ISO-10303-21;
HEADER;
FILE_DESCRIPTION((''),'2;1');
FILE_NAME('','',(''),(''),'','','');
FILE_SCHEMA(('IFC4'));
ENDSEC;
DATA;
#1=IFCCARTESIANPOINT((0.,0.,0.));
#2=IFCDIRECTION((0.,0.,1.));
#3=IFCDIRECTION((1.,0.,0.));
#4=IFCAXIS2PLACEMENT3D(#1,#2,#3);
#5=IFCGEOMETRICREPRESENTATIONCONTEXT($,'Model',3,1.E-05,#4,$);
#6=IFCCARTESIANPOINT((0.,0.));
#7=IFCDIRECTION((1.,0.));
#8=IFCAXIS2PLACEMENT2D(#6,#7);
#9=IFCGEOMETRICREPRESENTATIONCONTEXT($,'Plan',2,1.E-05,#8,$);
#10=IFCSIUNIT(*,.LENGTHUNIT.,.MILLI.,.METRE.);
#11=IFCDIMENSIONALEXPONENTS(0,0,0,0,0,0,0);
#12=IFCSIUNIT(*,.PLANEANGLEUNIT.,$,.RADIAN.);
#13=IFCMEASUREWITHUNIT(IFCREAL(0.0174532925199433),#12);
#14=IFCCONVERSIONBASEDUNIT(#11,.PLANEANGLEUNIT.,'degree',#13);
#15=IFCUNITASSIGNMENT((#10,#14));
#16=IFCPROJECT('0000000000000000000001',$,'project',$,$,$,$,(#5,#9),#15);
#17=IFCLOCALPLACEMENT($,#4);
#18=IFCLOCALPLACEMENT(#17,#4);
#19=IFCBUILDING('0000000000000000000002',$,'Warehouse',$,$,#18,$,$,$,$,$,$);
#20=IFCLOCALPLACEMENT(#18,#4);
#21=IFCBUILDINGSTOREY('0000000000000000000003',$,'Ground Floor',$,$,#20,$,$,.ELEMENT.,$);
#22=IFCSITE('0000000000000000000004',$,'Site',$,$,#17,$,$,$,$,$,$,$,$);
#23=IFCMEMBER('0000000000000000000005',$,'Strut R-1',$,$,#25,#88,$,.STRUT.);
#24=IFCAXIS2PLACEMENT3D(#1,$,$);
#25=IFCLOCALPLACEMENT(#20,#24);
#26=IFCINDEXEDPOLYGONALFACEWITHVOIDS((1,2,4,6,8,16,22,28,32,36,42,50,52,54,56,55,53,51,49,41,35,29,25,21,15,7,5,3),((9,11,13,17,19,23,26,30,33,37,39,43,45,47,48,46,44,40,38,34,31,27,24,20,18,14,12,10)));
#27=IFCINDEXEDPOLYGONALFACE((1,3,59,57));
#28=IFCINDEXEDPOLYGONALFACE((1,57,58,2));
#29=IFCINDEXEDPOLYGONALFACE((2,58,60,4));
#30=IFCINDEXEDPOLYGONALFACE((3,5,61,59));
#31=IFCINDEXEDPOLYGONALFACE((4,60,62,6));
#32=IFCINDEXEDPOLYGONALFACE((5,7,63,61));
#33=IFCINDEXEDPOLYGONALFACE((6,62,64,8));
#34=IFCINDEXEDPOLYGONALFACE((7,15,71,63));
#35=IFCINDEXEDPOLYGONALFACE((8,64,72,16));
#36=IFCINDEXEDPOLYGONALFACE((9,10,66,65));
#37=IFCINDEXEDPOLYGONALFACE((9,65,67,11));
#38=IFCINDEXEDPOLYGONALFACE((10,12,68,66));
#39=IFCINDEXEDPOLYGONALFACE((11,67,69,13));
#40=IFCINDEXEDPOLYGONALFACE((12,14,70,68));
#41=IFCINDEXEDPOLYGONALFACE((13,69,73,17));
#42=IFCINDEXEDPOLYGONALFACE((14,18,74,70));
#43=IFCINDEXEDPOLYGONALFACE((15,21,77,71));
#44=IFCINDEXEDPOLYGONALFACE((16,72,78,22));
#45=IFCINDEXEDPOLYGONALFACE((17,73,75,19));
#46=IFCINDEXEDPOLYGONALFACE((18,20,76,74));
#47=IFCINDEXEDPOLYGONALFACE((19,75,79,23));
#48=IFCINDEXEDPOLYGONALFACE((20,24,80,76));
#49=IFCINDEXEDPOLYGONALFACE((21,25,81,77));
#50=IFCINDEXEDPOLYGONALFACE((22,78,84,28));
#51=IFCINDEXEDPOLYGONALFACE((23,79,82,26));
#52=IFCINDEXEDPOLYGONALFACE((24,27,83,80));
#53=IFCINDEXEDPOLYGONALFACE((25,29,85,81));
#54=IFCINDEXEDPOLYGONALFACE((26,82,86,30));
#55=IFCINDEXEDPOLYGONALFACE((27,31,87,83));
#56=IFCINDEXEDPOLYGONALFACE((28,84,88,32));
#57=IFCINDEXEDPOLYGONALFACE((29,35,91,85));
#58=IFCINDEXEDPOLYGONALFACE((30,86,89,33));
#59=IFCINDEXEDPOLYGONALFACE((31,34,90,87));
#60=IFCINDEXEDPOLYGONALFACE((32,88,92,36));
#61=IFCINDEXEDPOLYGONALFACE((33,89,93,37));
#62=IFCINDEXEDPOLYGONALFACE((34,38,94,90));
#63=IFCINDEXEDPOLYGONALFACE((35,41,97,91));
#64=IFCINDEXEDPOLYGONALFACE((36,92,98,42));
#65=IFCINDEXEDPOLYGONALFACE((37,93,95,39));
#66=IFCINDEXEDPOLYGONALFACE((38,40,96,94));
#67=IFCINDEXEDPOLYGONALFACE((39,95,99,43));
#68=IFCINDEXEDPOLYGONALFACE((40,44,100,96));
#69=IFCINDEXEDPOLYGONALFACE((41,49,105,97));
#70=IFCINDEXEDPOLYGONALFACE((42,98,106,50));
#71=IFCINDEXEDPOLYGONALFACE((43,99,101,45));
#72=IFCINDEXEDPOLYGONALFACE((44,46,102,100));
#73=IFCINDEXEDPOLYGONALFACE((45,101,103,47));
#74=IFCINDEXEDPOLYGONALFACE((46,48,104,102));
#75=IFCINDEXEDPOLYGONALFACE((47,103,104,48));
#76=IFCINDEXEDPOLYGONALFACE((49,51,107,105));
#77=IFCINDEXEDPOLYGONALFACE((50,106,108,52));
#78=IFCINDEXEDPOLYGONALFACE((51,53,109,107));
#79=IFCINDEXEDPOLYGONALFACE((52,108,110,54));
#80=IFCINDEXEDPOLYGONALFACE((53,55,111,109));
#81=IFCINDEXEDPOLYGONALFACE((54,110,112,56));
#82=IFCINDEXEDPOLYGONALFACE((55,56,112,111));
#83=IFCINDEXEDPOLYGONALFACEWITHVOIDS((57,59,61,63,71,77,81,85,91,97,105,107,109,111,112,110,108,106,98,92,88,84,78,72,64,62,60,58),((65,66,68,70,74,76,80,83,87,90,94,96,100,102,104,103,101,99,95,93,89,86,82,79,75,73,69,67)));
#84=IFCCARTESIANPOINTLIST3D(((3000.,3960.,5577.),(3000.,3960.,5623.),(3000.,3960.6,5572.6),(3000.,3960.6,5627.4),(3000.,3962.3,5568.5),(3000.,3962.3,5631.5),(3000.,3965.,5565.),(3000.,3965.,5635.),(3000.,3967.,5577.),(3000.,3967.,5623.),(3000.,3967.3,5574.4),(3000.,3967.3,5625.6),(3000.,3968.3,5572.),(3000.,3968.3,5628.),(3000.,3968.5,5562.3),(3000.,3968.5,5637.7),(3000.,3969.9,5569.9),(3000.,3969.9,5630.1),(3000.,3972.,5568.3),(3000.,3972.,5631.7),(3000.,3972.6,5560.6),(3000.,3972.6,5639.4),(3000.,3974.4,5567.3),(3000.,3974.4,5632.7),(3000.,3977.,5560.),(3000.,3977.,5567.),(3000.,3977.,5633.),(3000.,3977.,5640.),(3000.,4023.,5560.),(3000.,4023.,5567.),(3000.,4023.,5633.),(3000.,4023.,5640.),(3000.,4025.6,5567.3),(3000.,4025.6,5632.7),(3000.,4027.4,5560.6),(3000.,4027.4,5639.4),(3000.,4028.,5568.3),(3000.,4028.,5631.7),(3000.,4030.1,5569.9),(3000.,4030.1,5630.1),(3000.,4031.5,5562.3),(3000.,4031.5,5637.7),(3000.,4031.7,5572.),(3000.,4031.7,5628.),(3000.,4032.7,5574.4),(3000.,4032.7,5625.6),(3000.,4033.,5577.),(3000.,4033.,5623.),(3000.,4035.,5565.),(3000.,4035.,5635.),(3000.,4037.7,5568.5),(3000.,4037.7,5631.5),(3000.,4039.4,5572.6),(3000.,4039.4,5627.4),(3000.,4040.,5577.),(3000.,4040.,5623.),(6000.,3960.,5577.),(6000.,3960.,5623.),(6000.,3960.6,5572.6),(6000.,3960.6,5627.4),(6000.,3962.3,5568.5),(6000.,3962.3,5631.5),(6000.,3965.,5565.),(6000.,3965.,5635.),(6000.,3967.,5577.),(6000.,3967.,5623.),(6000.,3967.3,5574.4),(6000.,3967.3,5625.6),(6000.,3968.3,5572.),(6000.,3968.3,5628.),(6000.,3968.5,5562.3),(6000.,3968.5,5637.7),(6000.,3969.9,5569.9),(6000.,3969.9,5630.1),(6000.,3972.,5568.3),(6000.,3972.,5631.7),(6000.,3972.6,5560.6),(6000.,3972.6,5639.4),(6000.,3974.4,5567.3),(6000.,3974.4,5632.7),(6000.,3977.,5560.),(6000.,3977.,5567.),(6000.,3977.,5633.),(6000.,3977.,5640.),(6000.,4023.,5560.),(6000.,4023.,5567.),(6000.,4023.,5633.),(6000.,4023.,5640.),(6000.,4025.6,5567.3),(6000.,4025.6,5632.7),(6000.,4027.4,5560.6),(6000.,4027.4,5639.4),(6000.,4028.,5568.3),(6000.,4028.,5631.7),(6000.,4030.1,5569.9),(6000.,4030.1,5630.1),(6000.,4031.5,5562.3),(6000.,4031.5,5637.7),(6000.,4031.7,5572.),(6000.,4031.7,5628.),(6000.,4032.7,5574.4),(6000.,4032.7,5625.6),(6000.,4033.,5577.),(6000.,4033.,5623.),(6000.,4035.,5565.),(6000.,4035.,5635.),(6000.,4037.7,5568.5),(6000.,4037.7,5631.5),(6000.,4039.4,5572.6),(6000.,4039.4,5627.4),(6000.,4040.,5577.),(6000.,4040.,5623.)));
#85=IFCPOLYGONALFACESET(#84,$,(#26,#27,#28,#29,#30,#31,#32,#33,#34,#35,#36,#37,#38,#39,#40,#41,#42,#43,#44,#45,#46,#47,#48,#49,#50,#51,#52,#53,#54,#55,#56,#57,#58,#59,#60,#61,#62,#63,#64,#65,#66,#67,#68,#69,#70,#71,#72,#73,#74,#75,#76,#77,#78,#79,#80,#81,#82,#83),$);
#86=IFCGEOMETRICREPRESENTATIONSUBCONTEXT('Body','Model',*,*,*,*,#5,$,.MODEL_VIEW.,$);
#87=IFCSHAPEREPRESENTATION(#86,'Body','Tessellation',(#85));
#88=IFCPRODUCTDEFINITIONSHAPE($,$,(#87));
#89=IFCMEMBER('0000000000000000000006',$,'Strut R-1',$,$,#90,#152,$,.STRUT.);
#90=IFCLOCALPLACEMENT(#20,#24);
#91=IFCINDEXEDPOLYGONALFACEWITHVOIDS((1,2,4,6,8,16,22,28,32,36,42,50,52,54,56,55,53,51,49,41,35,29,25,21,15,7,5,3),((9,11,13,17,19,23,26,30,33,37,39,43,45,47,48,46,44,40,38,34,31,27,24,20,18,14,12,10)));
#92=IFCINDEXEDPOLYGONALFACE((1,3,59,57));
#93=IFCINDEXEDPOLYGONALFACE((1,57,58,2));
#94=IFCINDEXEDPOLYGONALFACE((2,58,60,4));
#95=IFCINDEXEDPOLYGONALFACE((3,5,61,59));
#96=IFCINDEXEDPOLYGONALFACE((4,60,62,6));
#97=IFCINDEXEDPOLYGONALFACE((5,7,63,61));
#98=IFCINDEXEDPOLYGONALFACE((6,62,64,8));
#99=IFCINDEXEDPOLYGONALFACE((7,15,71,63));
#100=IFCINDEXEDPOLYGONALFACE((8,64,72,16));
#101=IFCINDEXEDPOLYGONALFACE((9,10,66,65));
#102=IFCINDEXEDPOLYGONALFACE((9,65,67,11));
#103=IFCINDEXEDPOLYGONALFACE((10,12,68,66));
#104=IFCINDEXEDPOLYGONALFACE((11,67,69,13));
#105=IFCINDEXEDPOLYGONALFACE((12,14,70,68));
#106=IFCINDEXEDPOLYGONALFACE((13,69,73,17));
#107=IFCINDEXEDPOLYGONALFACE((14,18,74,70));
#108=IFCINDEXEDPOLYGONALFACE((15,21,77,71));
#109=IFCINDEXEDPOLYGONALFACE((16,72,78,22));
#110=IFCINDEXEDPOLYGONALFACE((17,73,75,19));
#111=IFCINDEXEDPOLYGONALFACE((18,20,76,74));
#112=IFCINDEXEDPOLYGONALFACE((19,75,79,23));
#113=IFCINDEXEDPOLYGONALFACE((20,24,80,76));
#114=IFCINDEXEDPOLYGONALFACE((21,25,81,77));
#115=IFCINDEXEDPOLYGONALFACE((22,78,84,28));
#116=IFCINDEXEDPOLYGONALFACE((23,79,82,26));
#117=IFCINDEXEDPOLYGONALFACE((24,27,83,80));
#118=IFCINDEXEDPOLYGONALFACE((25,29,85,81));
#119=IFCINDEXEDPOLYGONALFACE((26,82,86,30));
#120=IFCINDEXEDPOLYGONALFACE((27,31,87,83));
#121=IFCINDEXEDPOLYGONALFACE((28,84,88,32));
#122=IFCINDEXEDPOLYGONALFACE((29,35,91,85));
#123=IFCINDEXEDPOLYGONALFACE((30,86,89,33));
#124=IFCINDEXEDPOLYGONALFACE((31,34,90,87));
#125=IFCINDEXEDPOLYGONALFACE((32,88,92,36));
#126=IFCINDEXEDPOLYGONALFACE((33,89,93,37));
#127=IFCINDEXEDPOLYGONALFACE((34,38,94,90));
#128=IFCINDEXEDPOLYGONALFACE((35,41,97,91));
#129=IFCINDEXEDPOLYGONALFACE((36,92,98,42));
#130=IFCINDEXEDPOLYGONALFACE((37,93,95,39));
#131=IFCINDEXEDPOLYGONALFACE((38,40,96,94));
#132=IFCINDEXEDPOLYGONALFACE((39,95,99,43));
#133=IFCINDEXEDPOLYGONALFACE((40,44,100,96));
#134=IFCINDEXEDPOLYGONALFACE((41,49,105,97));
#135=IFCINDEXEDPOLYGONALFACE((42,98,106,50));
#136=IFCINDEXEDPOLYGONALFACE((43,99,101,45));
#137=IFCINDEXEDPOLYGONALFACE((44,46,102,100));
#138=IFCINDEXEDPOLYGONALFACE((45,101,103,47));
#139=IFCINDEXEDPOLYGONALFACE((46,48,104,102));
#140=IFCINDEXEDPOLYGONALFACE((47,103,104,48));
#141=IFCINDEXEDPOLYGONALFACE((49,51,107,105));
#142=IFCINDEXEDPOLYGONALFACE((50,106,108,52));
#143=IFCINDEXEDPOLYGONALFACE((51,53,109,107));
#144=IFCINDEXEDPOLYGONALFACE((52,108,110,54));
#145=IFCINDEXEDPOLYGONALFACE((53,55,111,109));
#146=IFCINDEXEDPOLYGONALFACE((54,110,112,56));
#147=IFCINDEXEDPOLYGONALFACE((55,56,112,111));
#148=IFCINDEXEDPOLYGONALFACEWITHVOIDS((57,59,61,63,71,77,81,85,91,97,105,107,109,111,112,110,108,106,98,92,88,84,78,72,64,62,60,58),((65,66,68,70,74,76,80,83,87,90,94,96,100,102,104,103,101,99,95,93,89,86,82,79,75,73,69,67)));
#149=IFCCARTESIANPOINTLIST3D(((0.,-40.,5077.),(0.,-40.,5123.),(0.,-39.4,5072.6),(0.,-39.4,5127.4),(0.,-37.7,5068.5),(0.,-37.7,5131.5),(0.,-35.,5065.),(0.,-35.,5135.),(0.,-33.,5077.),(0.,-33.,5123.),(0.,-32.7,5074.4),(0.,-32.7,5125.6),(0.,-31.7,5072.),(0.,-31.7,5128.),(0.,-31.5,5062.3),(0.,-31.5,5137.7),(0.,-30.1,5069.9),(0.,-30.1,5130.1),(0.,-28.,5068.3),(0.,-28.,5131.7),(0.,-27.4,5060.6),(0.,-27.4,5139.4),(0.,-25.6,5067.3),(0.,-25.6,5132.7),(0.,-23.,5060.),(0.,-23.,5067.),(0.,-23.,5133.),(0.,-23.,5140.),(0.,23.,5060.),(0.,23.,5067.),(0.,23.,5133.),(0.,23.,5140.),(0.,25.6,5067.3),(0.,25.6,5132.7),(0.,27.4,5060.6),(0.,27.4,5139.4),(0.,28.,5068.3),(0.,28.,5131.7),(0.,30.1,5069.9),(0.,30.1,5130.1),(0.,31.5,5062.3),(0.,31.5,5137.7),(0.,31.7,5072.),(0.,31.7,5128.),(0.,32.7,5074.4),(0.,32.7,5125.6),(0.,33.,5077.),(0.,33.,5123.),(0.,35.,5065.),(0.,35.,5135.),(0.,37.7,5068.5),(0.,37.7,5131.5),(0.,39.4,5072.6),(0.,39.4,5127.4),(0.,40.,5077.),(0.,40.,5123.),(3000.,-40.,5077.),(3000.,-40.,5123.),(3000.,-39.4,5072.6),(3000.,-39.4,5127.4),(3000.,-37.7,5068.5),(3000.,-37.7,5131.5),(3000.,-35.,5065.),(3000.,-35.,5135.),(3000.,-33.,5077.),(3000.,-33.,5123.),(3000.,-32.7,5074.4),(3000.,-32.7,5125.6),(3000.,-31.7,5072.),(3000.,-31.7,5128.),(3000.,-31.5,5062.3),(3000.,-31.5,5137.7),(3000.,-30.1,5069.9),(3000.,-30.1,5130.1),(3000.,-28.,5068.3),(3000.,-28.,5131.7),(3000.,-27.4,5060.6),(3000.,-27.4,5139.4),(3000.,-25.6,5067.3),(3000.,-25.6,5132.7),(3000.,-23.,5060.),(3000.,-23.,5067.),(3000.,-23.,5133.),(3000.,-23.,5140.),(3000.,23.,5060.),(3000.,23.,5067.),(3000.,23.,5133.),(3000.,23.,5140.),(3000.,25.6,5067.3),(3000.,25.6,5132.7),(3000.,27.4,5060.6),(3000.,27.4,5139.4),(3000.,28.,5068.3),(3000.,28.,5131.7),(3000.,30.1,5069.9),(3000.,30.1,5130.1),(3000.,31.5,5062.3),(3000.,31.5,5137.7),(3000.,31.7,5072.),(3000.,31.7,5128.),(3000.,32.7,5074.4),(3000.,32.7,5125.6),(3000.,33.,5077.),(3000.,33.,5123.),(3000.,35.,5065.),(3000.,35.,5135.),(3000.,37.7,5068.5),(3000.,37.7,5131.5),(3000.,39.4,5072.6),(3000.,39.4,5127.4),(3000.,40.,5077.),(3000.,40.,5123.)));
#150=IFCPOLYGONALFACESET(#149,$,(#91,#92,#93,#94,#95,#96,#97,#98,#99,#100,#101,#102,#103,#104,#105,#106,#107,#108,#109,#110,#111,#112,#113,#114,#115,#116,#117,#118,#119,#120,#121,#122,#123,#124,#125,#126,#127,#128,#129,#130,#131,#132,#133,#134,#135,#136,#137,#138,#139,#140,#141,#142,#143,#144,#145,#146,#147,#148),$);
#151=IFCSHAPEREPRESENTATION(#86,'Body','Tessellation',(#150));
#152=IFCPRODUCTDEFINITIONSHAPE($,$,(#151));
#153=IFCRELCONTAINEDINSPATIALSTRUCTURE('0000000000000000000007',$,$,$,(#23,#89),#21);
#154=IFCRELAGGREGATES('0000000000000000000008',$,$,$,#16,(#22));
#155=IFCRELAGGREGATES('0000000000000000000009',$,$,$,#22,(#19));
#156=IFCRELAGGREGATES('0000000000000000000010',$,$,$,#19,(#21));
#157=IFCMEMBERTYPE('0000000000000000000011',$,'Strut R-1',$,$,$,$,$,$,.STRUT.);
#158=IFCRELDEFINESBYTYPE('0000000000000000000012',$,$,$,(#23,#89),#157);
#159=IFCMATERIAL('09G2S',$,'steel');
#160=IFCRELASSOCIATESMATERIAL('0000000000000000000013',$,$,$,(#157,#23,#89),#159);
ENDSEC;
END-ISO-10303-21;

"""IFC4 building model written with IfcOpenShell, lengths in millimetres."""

from ifc_helpers import new_model, entity, si_unit, converted_unit, frame, origin_with_axes, origin_2d_with_axis, place, context, subcontext, project, spatial, hollow_rectangle, extrude, material, material_profile, profile_set, profile_usage, type_object, element, save


model = new_model("IFC4")

# Units and contexts
model_context = context("Model", 3, precision=1e-05, world=origin_with_axes())
plan_context = context("Plan", 2, precision=1e-05, world=origin_2d_with_axis())
body_context = subcontext(model_context, "Body", "Model", "MODEL_VIEW")
ifc_project = project(units=[si_unit("LENGTHUNIT", "METRE", prefix="MILLI"), converted_unit("PLANEANGLEUNIT", "degree", entity("IfcReal", 0.0174532925199433), si_unit("PLANEANGLEUNIT", "RADIAN"), dimensions=[0, 0, 0, 0, 0, 0, 0])], contexts=[model_context, plan_context])

# Site, building, storey
site_placement = place(None, origin_with_axes())
site = spatial("IfcSite", under=ifc_project, at=site_placement, Name="Site")
building_placement = place(site_placement, origin_with_axes())
building = spatial("IfcBuilding", under=site, at=building_placement, Name="Warehouse")
storey_placement = place(building_placement, origin_with_axes())
storey = spatial("IfcBuildingStorey", under=building, at=storey_placement, Name="Ground Floor", CompositionType="ELEMENT")

# Members
ifc_material_1 = material(Name="09G2S", Category="steel")
ifc_material_profile_1 = material_profile(ifc_material_1, hollow_rectangle(XDim=80.0, YDim=80.0, WallThickness=7.0, InnerFilletRadius=10.0, OuterFilletRadius=17.0))
ifc_profile_set_1 = profile_set([ifc_material_profile_1], Name="PK80x7_09G2S")
member_type_1 = type_object("IfcMemberType", Name="Strut R-1", PredefinedType="STRUT", material=ifc_profile_set_1)
ifc_profile_usage_1 = profile_usage(ifc_profile_set_1, cardinal=5)
member_1_placement = place(storey_placement, frame((3000.0, 4000.0, 5600.0), z_axis=(1.0, 0.0, 0.0), x_axis=(0.0, 1.0, 0.0)))
element("IfcMember", 1, at=member_1_placement, inside=storey, type_object=member_type_1, material=ifc_profile_usage_1, Name="Strut R-1", PredefinedType="STRUT", context=body_context, shape_type="SweptSolid", body=[
    extrude(hollow_rectangle(XDim=80.0, YDim=80.0, WallThickness=7.0, InnerFilletRadius=10.0, OuterFilletRadius=17.0), origin_with_axes(), (0.0, 0.0, 1.0), 3000.0),
])
ifc_profile_usage_2 = profile_usage(ifc_profile_set_1, cardinal=5)
member_2_placement = place(storey_placement, frame((0.0, 0.0, 5100.0), z_axis=(1.0, 0.0, 0.0), x_axis=(0.0, 1.0, 0.0)))
element("IfcMember", 2, at=member_2_placement, inside=storey, type_object=member_type_1, material=ifc_profile_usage_2, Name="Strut R-1", PredefinedType="STRUT", context=body_context, shape_type="SweptSolid", body=[
    extrude(hollow_rectangle(XDim=80.0, YDim=80.0, WallThickness=7.0, InnerFilletRadius=10.0, OuterFilletRadius=17.0), origin_with_axes(), (0.0, 0.0, 1.0), 3000.0),
])

save(model, "model.ifc")
